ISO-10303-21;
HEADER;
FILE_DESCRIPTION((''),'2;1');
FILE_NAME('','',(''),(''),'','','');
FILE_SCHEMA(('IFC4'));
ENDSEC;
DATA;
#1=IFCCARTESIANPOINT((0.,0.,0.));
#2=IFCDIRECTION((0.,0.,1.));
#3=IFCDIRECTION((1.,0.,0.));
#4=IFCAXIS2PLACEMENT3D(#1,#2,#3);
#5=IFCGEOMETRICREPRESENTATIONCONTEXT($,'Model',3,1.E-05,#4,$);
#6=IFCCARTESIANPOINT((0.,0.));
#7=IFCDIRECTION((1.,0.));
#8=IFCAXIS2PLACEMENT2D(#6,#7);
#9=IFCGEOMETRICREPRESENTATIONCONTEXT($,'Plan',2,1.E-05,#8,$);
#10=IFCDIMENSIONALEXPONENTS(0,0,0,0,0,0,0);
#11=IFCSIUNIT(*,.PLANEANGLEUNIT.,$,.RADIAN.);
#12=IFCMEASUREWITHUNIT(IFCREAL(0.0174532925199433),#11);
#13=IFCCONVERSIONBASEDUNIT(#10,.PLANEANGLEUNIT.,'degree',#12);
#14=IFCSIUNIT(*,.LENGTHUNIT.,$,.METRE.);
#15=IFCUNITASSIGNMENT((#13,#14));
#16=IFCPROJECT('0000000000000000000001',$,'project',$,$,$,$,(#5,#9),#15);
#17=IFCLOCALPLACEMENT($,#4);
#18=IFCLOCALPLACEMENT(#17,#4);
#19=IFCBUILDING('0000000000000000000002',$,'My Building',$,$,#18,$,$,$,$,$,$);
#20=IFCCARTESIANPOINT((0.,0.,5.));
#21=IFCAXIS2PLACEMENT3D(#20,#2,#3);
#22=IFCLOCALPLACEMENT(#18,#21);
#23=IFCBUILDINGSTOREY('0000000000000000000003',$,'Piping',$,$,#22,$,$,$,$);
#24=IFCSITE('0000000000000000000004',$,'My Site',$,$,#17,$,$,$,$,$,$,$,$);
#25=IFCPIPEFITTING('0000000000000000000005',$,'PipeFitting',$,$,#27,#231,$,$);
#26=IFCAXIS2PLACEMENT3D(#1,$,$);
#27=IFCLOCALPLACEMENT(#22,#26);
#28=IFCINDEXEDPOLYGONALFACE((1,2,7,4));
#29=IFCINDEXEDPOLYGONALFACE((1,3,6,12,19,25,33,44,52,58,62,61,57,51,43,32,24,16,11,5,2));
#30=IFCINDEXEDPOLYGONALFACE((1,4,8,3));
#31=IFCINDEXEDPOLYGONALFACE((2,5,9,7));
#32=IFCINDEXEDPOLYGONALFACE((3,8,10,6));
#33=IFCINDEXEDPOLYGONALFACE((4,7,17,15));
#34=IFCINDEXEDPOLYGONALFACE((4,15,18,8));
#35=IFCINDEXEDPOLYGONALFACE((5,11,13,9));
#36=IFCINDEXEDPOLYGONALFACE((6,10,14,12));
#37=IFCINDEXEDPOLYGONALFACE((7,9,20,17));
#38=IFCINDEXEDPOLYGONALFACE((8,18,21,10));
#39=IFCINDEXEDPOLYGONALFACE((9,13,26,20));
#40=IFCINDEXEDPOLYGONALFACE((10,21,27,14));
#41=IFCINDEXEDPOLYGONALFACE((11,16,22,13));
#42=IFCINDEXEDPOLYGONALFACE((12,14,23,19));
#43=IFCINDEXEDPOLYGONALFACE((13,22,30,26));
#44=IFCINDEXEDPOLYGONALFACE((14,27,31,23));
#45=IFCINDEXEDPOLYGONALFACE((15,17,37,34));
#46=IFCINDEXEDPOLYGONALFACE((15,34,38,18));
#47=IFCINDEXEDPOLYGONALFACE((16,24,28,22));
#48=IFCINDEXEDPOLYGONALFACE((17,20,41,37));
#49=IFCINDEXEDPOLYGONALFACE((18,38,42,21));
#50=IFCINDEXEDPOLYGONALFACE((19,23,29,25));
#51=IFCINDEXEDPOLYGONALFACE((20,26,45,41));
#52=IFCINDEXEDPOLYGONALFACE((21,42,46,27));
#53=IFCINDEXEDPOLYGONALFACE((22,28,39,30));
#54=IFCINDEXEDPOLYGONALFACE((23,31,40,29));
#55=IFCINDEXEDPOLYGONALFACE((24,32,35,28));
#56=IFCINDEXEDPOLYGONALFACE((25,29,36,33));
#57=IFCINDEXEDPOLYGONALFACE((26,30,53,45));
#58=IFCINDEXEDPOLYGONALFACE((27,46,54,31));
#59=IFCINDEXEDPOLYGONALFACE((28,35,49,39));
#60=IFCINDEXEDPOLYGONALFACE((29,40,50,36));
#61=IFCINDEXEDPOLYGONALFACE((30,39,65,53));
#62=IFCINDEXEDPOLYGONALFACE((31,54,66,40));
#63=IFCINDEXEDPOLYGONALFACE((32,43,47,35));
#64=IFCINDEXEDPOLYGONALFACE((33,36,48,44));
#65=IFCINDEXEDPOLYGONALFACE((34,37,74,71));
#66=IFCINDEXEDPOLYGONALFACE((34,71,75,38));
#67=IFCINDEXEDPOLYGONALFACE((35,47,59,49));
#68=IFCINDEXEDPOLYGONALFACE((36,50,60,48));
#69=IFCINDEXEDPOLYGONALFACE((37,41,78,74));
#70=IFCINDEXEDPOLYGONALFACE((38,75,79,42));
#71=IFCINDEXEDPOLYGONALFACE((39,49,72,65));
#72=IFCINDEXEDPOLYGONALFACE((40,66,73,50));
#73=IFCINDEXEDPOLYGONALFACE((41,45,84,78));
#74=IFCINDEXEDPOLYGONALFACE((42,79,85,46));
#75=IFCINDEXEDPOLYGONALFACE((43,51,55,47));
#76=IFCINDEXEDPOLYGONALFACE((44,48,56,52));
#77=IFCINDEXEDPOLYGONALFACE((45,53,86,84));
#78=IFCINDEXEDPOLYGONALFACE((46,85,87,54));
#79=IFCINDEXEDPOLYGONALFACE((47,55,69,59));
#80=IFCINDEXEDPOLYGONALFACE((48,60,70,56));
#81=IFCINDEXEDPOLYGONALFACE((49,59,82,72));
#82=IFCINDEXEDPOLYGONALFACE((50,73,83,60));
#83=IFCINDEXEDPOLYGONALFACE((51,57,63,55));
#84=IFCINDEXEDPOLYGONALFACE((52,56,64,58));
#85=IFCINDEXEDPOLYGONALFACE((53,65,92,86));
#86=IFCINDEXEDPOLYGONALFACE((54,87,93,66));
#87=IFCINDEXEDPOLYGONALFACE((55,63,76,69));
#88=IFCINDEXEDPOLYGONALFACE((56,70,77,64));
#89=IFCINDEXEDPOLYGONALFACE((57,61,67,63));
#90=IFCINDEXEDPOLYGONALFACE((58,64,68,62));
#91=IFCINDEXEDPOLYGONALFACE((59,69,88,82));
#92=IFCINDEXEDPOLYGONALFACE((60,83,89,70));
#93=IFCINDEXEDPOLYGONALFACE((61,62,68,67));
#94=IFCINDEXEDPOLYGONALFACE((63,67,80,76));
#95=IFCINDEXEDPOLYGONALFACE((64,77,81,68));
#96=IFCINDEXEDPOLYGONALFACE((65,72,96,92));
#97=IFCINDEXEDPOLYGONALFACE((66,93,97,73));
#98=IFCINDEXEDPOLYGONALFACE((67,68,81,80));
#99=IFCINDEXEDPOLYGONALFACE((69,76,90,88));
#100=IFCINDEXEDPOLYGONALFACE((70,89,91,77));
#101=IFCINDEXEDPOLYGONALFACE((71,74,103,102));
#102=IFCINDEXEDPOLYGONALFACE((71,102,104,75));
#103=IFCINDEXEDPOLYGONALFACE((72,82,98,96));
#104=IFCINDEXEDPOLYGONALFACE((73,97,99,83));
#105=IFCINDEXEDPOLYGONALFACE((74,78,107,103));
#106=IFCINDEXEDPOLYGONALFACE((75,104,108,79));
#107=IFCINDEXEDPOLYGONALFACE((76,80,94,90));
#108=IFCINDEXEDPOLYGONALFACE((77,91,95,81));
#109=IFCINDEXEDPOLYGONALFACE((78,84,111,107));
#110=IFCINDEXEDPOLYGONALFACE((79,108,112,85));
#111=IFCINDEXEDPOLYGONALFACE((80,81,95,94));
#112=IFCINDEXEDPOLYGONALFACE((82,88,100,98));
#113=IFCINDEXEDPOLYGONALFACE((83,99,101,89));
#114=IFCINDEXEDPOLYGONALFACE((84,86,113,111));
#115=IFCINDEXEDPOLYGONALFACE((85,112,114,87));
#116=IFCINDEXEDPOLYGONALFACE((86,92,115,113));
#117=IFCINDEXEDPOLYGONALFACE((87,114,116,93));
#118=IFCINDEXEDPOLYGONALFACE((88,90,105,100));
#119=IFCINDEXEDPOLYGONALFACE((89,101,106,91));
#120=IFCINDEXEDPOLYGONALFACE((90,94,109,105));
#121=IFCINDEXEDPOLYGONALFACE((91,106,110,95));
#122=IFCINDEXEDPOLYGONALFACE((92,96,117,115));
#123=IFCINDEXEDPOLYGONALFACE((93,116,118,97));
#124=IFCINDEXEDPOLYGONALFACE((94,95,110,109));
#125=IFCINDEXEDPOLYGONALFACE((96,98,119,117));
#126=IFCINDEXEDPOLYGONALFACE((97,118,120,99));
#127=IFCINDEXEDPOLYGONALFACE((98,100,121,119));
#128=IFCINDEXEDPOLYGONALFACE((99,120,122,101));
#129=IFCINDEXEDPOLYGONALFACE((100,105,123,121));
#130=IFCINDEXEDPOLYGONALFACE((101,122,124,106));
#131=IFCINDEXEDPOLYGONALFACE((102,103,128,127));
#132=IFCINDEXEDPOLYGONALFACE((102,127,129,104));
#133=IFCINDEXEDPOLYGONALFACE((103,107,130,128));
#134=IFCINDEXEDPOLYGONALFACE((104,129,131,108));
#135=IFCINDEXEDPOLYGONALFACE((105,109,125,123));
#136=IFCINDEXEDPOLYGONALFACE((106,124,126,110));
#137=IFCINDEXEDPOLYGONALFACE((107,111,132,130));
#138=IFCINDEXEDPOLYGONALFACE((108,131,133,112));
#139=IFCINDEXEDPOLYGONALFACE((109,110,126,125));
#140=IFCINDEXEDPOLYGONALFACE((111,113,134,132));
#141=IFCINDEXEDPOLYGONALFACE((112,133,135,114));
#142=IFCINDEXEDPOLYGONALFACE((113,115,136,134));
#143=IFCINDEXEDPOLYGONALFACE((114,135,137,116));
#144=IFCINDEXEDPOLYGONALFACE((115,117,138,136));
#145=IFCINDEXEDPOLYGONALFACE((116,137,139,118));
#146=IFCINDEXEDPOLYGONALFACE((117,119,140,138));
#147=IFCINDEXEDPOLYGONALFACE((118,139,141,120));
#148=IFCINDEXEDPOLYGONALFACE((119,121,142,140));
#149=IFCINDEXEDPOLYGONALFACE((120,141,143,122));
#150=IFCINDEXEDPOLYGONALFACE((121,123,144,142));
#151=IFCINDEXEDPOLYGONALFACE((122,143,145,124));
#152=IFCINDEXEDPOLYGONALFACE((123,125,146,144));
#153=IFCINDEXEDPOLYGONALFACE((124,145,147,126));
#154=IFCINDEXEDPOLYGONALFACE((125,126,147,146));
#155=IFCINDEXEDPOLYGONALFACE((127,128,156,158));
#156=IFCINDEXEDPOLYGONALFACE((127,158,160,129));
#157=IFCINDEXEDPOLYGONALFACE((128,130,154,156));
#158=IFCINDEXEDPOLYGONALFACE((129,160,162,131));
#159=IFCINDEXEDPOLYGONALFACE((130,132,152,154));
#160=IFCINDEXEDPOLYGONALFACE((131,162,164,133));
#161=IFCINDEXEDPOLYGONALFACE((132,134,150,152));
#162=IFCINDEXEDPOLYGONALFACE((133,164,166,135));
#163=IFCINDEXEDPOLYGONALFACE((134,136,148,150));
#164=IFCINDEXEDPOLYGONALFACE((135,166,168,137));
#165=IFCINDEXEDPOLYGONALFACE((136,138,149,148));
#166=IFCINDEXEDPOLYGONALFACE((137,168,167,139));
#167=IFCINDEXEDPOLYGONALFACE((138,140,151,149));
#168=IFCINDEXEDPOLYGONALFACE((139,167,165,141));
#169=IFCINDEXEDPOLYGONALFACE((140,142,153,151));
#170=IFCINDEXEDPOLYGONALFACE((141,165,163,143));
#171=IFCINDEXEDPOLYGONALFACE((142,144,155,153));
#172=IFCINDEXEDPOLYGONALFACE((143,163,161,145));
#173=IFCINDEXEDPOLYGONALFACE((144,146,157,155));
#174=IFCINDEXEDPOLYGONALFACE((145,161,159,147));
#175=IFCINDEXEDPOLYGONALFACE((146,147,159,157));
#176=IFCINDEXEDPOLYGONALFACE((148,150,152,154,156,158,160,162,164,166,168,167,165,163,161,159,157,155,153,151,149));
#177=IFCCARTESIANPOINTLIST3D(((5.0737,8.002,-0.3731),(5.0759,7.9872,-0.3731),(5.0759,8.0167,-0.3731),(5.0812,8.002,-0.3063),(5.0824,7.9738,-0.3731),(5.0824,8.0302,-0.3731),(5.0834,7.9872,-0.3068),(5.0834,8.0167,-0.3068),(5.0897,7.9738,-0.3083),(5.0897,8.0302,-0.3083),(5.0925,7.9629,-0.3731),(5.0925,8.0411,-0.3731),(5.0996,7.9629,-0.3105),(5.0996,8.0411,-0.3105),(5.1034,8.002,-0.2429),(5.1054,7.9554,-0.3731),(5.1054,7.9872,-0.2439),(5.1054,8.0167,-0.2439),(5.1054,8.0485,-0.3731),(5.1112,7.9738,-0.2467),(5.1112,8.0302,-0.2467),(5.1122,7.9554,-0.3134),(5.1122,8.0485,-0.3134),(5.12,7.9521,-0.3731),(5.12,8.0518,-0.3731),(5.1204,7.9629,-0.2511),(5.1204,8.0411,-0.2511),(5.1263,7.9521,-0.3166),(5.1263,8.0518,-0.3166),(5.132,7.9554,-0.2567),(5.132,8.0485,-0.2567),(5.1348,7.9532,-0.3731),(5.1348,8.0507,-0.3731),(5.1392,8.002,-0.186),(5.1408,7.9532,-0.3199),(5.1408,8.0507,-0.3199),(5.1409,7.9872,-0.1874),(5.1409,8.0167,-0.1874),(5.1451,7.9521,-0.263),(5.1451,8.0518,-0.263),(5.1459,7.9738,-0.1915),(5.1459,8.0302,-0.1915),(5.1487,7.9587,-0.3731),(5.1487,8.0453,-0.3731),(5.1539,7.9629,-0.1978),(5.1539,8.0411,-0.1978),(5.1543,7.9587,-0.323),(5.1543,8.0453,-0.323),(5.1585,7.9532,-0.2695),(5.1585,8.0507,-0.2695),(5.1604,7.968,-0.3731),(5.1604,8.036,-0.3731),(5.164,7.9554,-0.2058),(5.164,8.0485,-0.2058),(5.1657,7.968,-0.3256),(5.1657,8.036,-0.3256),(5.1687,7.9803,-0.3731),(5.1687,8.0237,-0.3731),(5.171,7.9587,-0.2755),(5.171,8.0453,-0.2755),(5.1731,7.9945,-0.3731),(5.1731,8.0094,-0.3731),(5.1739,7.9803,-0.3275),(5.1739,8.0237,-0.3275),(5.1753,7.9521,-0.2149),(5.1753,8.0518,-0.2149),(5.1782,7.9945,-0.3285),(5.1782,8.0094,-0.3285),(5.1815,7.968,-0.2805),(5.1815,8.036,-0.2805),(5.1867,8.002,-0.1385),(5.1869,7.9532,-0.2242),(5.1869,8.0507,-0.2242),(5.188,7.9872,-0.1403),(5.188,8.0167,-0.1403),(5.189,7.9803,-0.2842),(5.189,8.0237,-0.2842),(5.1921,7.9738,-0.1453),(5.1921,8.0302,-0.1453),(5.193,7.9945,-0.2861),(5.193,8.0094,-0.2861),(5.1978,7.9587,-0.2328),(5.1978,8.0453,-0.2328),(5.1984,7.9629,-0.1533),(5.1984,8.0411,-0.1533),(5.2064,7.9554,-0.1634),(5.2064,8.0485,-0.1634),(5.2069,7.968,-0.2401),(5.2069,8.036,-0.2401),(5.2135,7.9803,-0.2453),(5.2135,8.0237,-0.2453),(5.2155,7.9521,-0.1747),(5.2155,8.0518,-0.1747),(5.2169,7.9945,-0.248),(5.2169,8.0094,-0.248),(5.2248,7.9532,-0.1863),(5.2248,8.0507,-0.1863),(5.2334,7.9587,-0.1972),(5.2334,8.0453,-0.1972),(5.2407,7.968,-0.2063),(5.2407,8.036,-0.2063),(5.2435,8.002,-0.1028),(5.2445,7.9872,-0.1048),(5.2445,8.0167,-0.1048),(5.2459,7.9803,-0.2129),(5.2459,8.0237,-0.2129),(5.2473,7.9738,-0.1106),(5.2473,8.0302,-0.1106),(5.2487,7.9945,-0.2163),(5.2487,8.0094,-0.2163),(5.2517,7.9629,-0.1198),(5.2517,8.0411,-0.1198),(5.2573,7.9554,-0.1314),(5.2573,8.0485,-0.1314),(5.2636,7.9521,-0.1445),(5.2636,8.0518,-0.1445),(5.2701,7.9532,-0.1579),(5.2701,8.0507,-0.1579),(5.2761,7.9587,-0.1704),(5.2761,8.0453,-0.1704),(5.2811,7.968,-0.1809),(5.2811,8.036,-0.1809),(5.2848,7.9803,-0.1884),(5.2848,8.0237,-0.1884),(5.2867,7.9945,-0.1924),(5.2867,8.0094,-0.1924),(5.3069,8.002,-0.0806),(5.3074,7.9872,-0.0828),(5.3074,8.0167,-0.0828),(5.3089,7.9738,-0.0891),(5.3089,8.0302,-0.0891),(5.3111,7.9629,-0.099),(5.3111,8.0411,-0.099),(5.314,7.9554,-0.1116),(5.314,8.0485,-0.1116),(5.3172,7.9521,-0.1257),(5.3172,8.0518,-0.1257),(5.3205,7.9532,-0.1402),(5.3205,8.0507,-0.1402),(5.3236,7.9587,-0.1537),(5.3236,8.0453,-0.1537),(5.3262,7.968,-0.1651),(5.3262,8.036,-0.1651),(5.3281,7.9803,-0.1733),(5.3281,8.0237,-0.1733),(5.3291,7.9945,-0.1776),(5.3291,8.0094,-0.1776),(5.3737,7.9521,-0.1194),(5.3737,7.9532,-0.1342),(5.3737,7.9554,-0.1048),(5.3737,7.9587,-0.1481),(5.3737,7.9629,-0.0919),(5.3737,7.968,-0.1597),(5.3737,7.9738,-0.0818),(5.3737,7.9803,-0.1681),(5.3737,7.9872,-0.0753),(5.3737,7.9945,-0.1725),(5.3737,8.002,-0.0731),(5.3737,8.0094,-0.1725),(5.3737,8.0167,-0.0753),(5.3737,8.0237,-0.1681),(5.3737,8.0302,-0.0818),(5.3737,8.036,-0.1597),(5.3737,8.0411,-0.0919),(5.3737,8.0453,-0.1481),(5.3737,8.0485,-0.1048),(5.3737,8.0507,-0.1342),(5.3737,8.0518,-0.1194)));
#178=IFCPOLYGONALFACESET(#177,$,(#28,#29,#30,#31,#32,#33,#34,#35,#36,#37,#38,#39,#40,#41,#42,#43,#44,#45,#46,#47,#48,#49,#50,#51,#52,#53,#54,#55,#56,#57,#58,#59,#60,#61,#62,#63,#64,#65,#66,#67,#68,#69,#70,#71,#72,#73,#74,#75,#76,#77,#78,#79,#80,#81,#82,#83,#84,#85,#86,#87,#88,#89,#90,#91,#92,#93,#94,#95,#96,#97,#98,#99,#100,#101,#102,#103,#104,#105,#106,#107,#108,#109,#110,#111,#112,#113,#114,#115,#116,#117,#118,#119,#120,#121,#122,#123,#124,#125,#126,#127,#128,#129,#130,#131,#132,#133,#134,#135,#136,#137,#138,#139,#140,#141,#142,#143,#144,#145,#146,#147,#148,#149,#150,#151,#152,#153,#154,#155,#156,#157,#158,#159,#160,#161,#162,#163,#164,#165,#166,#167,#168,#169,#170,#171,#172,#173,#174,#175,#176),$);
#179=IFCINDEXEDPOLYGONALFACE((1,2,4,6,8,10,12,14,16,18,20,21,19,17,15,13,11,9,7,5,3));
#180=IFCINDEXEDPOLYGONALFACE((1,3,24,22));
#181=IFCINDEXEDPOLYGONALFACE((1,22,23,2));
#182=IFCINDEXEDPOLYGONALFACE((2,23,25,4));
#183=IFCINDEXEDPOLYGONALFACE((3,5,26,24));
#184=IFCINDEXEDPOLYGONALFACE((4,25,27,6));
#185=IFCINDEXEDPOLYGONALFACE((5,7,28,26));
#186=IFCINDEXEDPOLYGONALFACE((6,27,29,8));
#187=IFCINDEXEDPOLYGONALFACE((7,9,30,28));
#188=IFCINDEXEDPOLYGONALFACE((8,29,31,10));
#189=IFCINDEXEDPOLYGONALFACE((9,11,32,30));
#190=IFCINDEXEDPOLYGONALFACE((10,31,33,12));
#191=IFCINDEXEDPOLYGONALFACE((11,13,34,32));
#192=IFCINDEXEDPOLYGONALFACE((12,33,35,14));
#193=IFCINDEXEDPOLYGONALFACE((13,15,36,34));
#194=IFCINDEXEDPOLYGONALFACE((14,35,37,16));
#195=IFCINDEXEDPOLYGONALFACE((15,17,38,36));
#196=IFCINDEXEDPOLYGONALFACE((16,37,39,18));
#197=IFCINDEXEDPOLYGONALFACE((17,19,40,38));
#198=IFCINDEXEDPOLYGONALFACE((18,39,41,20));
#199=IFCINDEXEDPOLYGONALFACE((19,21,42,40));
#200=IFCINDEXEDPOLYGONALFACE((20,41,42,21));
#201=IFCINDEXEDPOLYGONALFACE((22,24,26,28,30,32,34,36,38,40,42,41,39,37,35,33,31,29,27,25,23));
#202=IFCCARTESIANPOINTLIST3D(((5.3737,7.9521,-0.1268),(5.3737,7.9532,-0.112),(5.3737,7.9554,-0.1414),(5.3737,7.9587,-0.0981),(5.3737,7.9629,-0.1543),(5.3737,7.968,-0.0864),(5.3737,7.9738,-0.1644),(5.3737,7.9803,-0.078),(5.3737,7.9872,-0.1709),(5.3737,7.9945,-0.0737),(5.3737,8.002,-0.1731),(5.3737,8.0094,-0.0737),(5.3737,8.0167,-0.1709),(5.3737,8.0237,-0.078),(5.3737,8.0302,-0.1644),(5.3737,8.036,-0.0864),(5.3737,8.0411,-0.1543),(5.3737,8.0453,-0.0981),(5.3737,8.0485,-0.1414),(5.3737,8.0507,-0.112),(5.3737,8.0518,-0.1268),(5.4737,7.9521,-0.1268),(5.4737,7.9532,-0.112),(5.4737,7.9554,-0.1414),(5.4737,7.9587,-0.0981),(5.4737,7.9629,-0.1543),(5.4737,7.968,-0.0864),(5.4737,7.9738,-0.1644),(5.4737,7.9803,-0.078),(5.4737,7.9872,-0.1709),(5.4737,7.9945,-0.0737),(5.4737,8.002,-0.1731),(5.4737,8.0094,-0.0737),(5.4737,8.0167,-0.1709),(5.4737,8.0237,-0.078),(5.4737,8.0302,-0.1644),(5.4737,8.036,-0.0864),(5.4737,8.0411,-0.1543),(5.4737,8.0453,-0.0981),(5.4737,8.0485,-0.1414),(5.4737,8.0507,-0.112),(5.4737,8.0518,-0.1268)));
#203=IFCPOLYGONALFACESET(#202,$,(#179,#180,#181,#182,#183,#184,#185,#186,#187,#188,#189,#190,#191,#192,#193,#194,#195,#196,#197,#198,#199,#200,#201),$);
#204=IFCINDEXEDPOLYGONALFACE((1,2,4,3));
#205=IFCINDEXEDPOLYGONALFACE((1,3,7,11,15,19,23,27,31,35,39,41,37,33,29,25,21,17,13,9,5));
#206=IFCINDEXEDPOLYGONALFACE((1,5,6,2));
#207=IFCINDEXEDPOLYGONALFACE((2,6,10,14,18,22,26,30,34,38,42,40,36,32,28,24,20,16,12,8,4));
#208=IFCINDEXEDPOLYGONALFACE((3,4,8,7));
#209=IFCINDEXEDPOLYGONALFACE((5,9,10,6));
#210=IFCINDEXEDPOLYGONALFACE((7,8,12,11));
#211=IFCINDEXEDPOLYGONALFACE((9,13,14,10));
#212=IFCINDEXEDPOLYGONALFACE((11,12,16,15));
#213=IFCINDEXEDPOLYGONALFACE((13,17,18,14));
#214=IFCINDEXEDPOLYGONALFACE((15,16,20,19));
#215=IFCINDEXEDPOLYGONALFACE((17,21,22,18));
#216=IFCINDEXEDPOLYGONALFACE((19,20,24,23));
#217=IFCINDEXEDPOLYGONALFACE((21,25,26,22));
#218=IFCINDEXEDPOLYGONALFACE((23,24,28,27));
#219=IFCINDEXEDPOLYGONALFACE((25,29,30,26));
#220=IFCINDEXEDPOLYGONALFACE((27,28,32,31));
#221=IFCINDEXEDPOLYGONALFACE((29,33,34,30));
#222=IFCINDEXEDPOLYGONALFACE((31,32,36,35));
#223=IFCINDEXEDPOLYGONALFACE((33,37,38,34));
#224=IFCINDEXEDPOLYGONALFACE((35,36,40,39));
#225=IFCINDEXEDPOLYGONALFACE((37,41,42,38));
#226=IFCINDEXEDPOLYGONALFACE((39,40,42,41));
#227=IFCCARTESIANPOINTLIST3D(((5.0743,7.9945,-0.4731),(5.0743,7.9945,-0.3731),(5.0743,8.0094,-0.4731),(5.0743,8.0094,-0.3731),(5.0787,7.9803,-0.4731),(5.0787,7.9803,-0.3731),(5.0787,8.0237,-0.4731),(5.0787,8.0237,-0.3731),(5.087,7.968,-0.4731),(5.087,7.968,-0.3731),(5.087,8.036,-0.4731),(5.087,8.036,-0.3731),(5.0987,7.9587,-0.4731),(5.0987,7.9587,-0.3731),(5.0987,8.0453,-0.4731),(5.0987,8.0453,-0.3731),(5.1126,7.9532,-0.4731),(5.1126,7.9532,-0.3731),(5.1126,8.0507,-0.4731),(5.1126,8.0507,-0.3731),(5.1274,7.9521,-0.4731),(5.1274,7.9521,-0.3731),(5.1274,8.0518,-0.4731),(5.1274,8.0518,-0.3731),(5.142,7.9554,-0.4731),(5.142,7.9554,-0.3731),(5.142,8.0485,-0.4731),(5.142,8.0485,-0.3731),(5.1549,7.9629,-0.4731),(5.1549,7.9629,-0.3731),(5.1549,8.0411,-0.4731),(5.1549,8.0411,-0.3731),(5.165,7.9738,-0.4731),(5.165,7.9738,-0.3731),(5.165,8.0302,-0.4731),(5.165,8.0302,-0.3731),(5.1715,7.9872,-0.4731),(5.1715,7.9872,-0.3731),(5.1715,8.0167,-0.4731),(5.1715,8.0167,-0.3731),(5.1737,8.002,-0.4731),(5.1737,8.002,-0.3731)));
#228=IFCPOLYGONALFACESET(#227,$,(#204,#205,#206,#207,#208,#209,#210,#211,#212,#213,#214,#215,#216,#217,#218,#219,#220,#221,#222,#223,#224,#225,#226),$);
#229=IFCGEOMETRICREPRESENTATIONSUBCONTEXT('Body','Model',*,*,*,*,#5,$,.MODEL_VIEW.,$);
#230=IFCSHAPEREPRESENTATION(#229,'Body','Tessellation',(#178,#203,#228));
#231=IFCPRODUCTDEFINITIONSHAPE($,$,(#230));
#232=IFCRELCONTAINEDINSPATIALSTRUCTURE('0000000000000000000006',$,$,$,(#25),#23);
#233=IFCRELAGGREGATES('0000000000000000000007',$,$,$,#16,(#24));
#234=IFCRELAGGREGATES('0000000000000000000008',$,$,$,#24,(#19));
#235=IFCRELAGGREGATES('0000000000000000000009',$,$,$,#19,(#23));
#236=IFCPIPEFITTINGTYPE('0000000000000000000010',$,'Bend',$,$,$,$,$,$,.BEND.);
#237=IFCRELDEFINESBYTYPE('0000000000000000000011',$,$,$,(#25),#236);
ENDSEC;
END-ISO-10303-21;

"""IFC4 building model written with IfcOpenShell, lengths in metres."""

from ifc_helpers import new_model, entity, si_unit, converted_unit, frame, origin_with_axes, origin_2d_with_axis, place, context, subcontext, project, spatial, circle, extrude, source, transform, mapped, type_object, type_shapes, element, save


model = new_model("IFC4")

# Units and contexts
model_context = context("Model", 3, precision=1e-05, world=origin_with_axes())
plan_context = context("Plan", 2, precision=1e-05, world=origin_2d_with_axis())
body_context = subcontext(model_context, "Body", "Model", "MODEL_VIEW")
ifc_project = project(units=[converted_unit("PLANEANGLEUNIT", "degree", entity("IfcReal", 0.0174532925199433), si_unit("PLANEANGLEUNIT", "RADIAN"), dimensions=[0, 0, 0, 0, 0, 0, 0]), si_unit("LENGTHUNIT", "METRE")], contexts=[model_context, plan_context])

# Site, building, storey
site_placement = place(None, origin_with_axes())
site = spatial("IfcSite", under=ifc_project, at=site_placement, Name="My Site")
building_placement = place(site_placement, origin_with_axes())
building = spatial("IfcBuilding", under=site, at=building_placement, Name="My Building")
storey_placement = place(building_placement, frame((0.0, 0.0, 5.0), z_axis=(0.0, 0.0, 1.0), x_axis=(1.0, 0.0, 0.0)))
storey = spatial("IfcBuildingStorey", under=building, at=storey_placement, Name="Piping")

# Pipe fitting
pipe_fitting_type_1 = type_object("IfcPipeFittingType", Name="Bend", PredefinedType="BEND")
shared_shape = source(origin_with_axes(), body_context, "Body", "SolidModel", [
    entity("IfcSweptDiskSolid", entity("IfcIndexedPolyCurve", entity("IfcCartesianPointList3D", [[0.0, 0.0, -0.1], [0.0732, 0.0, -0.2768], [0.25, 0.0, -0.35]]), [entity("IfcArcIndex", [1, 2, 3])]), 0.05),
    extrude(circle(Radius=0.05), origin_with_axes(), (0.0, 0.0, -1.0), 0.1),
    extrude(circle(Radius=0.05), frame((0.25, 0.0, -0.35), z_axis=(1.0, 0.0, 0.0), x_axis=(0.0, 0.0, 1.0)), (0.0, 0.0, 1.0), 0.1),
])
type_shapes(pipe_fitting_type_1, [shared_shape])
for number, where, z_axis, x_axis, name in (
    (1, (5.4737, 8.002, -0.1231), (1.0, 0.000001, 0.0), (0.0, 0.0, -1.0), "PipeFitting"),
):
    element("IfcPipeFitting", number, at=place(storey_placement, frame(where, z_axis=z_axis, x_axis=x_axis)), inside=storey, type_object=pipe_fitting_type_1, Name=name, context=body_context, shape_type="MappedRepresentation", body=[
        mapped(shared_shape, transform((0.0, 0.0, 0.0), x_axis=(1.0, 0.0, 0.0), y_axis=(0.0, 1.0, 0.0), z_axis=(0.0, 0.0, 1.0), scale=1.0)),
    ])

save(model, "model.ifc")
